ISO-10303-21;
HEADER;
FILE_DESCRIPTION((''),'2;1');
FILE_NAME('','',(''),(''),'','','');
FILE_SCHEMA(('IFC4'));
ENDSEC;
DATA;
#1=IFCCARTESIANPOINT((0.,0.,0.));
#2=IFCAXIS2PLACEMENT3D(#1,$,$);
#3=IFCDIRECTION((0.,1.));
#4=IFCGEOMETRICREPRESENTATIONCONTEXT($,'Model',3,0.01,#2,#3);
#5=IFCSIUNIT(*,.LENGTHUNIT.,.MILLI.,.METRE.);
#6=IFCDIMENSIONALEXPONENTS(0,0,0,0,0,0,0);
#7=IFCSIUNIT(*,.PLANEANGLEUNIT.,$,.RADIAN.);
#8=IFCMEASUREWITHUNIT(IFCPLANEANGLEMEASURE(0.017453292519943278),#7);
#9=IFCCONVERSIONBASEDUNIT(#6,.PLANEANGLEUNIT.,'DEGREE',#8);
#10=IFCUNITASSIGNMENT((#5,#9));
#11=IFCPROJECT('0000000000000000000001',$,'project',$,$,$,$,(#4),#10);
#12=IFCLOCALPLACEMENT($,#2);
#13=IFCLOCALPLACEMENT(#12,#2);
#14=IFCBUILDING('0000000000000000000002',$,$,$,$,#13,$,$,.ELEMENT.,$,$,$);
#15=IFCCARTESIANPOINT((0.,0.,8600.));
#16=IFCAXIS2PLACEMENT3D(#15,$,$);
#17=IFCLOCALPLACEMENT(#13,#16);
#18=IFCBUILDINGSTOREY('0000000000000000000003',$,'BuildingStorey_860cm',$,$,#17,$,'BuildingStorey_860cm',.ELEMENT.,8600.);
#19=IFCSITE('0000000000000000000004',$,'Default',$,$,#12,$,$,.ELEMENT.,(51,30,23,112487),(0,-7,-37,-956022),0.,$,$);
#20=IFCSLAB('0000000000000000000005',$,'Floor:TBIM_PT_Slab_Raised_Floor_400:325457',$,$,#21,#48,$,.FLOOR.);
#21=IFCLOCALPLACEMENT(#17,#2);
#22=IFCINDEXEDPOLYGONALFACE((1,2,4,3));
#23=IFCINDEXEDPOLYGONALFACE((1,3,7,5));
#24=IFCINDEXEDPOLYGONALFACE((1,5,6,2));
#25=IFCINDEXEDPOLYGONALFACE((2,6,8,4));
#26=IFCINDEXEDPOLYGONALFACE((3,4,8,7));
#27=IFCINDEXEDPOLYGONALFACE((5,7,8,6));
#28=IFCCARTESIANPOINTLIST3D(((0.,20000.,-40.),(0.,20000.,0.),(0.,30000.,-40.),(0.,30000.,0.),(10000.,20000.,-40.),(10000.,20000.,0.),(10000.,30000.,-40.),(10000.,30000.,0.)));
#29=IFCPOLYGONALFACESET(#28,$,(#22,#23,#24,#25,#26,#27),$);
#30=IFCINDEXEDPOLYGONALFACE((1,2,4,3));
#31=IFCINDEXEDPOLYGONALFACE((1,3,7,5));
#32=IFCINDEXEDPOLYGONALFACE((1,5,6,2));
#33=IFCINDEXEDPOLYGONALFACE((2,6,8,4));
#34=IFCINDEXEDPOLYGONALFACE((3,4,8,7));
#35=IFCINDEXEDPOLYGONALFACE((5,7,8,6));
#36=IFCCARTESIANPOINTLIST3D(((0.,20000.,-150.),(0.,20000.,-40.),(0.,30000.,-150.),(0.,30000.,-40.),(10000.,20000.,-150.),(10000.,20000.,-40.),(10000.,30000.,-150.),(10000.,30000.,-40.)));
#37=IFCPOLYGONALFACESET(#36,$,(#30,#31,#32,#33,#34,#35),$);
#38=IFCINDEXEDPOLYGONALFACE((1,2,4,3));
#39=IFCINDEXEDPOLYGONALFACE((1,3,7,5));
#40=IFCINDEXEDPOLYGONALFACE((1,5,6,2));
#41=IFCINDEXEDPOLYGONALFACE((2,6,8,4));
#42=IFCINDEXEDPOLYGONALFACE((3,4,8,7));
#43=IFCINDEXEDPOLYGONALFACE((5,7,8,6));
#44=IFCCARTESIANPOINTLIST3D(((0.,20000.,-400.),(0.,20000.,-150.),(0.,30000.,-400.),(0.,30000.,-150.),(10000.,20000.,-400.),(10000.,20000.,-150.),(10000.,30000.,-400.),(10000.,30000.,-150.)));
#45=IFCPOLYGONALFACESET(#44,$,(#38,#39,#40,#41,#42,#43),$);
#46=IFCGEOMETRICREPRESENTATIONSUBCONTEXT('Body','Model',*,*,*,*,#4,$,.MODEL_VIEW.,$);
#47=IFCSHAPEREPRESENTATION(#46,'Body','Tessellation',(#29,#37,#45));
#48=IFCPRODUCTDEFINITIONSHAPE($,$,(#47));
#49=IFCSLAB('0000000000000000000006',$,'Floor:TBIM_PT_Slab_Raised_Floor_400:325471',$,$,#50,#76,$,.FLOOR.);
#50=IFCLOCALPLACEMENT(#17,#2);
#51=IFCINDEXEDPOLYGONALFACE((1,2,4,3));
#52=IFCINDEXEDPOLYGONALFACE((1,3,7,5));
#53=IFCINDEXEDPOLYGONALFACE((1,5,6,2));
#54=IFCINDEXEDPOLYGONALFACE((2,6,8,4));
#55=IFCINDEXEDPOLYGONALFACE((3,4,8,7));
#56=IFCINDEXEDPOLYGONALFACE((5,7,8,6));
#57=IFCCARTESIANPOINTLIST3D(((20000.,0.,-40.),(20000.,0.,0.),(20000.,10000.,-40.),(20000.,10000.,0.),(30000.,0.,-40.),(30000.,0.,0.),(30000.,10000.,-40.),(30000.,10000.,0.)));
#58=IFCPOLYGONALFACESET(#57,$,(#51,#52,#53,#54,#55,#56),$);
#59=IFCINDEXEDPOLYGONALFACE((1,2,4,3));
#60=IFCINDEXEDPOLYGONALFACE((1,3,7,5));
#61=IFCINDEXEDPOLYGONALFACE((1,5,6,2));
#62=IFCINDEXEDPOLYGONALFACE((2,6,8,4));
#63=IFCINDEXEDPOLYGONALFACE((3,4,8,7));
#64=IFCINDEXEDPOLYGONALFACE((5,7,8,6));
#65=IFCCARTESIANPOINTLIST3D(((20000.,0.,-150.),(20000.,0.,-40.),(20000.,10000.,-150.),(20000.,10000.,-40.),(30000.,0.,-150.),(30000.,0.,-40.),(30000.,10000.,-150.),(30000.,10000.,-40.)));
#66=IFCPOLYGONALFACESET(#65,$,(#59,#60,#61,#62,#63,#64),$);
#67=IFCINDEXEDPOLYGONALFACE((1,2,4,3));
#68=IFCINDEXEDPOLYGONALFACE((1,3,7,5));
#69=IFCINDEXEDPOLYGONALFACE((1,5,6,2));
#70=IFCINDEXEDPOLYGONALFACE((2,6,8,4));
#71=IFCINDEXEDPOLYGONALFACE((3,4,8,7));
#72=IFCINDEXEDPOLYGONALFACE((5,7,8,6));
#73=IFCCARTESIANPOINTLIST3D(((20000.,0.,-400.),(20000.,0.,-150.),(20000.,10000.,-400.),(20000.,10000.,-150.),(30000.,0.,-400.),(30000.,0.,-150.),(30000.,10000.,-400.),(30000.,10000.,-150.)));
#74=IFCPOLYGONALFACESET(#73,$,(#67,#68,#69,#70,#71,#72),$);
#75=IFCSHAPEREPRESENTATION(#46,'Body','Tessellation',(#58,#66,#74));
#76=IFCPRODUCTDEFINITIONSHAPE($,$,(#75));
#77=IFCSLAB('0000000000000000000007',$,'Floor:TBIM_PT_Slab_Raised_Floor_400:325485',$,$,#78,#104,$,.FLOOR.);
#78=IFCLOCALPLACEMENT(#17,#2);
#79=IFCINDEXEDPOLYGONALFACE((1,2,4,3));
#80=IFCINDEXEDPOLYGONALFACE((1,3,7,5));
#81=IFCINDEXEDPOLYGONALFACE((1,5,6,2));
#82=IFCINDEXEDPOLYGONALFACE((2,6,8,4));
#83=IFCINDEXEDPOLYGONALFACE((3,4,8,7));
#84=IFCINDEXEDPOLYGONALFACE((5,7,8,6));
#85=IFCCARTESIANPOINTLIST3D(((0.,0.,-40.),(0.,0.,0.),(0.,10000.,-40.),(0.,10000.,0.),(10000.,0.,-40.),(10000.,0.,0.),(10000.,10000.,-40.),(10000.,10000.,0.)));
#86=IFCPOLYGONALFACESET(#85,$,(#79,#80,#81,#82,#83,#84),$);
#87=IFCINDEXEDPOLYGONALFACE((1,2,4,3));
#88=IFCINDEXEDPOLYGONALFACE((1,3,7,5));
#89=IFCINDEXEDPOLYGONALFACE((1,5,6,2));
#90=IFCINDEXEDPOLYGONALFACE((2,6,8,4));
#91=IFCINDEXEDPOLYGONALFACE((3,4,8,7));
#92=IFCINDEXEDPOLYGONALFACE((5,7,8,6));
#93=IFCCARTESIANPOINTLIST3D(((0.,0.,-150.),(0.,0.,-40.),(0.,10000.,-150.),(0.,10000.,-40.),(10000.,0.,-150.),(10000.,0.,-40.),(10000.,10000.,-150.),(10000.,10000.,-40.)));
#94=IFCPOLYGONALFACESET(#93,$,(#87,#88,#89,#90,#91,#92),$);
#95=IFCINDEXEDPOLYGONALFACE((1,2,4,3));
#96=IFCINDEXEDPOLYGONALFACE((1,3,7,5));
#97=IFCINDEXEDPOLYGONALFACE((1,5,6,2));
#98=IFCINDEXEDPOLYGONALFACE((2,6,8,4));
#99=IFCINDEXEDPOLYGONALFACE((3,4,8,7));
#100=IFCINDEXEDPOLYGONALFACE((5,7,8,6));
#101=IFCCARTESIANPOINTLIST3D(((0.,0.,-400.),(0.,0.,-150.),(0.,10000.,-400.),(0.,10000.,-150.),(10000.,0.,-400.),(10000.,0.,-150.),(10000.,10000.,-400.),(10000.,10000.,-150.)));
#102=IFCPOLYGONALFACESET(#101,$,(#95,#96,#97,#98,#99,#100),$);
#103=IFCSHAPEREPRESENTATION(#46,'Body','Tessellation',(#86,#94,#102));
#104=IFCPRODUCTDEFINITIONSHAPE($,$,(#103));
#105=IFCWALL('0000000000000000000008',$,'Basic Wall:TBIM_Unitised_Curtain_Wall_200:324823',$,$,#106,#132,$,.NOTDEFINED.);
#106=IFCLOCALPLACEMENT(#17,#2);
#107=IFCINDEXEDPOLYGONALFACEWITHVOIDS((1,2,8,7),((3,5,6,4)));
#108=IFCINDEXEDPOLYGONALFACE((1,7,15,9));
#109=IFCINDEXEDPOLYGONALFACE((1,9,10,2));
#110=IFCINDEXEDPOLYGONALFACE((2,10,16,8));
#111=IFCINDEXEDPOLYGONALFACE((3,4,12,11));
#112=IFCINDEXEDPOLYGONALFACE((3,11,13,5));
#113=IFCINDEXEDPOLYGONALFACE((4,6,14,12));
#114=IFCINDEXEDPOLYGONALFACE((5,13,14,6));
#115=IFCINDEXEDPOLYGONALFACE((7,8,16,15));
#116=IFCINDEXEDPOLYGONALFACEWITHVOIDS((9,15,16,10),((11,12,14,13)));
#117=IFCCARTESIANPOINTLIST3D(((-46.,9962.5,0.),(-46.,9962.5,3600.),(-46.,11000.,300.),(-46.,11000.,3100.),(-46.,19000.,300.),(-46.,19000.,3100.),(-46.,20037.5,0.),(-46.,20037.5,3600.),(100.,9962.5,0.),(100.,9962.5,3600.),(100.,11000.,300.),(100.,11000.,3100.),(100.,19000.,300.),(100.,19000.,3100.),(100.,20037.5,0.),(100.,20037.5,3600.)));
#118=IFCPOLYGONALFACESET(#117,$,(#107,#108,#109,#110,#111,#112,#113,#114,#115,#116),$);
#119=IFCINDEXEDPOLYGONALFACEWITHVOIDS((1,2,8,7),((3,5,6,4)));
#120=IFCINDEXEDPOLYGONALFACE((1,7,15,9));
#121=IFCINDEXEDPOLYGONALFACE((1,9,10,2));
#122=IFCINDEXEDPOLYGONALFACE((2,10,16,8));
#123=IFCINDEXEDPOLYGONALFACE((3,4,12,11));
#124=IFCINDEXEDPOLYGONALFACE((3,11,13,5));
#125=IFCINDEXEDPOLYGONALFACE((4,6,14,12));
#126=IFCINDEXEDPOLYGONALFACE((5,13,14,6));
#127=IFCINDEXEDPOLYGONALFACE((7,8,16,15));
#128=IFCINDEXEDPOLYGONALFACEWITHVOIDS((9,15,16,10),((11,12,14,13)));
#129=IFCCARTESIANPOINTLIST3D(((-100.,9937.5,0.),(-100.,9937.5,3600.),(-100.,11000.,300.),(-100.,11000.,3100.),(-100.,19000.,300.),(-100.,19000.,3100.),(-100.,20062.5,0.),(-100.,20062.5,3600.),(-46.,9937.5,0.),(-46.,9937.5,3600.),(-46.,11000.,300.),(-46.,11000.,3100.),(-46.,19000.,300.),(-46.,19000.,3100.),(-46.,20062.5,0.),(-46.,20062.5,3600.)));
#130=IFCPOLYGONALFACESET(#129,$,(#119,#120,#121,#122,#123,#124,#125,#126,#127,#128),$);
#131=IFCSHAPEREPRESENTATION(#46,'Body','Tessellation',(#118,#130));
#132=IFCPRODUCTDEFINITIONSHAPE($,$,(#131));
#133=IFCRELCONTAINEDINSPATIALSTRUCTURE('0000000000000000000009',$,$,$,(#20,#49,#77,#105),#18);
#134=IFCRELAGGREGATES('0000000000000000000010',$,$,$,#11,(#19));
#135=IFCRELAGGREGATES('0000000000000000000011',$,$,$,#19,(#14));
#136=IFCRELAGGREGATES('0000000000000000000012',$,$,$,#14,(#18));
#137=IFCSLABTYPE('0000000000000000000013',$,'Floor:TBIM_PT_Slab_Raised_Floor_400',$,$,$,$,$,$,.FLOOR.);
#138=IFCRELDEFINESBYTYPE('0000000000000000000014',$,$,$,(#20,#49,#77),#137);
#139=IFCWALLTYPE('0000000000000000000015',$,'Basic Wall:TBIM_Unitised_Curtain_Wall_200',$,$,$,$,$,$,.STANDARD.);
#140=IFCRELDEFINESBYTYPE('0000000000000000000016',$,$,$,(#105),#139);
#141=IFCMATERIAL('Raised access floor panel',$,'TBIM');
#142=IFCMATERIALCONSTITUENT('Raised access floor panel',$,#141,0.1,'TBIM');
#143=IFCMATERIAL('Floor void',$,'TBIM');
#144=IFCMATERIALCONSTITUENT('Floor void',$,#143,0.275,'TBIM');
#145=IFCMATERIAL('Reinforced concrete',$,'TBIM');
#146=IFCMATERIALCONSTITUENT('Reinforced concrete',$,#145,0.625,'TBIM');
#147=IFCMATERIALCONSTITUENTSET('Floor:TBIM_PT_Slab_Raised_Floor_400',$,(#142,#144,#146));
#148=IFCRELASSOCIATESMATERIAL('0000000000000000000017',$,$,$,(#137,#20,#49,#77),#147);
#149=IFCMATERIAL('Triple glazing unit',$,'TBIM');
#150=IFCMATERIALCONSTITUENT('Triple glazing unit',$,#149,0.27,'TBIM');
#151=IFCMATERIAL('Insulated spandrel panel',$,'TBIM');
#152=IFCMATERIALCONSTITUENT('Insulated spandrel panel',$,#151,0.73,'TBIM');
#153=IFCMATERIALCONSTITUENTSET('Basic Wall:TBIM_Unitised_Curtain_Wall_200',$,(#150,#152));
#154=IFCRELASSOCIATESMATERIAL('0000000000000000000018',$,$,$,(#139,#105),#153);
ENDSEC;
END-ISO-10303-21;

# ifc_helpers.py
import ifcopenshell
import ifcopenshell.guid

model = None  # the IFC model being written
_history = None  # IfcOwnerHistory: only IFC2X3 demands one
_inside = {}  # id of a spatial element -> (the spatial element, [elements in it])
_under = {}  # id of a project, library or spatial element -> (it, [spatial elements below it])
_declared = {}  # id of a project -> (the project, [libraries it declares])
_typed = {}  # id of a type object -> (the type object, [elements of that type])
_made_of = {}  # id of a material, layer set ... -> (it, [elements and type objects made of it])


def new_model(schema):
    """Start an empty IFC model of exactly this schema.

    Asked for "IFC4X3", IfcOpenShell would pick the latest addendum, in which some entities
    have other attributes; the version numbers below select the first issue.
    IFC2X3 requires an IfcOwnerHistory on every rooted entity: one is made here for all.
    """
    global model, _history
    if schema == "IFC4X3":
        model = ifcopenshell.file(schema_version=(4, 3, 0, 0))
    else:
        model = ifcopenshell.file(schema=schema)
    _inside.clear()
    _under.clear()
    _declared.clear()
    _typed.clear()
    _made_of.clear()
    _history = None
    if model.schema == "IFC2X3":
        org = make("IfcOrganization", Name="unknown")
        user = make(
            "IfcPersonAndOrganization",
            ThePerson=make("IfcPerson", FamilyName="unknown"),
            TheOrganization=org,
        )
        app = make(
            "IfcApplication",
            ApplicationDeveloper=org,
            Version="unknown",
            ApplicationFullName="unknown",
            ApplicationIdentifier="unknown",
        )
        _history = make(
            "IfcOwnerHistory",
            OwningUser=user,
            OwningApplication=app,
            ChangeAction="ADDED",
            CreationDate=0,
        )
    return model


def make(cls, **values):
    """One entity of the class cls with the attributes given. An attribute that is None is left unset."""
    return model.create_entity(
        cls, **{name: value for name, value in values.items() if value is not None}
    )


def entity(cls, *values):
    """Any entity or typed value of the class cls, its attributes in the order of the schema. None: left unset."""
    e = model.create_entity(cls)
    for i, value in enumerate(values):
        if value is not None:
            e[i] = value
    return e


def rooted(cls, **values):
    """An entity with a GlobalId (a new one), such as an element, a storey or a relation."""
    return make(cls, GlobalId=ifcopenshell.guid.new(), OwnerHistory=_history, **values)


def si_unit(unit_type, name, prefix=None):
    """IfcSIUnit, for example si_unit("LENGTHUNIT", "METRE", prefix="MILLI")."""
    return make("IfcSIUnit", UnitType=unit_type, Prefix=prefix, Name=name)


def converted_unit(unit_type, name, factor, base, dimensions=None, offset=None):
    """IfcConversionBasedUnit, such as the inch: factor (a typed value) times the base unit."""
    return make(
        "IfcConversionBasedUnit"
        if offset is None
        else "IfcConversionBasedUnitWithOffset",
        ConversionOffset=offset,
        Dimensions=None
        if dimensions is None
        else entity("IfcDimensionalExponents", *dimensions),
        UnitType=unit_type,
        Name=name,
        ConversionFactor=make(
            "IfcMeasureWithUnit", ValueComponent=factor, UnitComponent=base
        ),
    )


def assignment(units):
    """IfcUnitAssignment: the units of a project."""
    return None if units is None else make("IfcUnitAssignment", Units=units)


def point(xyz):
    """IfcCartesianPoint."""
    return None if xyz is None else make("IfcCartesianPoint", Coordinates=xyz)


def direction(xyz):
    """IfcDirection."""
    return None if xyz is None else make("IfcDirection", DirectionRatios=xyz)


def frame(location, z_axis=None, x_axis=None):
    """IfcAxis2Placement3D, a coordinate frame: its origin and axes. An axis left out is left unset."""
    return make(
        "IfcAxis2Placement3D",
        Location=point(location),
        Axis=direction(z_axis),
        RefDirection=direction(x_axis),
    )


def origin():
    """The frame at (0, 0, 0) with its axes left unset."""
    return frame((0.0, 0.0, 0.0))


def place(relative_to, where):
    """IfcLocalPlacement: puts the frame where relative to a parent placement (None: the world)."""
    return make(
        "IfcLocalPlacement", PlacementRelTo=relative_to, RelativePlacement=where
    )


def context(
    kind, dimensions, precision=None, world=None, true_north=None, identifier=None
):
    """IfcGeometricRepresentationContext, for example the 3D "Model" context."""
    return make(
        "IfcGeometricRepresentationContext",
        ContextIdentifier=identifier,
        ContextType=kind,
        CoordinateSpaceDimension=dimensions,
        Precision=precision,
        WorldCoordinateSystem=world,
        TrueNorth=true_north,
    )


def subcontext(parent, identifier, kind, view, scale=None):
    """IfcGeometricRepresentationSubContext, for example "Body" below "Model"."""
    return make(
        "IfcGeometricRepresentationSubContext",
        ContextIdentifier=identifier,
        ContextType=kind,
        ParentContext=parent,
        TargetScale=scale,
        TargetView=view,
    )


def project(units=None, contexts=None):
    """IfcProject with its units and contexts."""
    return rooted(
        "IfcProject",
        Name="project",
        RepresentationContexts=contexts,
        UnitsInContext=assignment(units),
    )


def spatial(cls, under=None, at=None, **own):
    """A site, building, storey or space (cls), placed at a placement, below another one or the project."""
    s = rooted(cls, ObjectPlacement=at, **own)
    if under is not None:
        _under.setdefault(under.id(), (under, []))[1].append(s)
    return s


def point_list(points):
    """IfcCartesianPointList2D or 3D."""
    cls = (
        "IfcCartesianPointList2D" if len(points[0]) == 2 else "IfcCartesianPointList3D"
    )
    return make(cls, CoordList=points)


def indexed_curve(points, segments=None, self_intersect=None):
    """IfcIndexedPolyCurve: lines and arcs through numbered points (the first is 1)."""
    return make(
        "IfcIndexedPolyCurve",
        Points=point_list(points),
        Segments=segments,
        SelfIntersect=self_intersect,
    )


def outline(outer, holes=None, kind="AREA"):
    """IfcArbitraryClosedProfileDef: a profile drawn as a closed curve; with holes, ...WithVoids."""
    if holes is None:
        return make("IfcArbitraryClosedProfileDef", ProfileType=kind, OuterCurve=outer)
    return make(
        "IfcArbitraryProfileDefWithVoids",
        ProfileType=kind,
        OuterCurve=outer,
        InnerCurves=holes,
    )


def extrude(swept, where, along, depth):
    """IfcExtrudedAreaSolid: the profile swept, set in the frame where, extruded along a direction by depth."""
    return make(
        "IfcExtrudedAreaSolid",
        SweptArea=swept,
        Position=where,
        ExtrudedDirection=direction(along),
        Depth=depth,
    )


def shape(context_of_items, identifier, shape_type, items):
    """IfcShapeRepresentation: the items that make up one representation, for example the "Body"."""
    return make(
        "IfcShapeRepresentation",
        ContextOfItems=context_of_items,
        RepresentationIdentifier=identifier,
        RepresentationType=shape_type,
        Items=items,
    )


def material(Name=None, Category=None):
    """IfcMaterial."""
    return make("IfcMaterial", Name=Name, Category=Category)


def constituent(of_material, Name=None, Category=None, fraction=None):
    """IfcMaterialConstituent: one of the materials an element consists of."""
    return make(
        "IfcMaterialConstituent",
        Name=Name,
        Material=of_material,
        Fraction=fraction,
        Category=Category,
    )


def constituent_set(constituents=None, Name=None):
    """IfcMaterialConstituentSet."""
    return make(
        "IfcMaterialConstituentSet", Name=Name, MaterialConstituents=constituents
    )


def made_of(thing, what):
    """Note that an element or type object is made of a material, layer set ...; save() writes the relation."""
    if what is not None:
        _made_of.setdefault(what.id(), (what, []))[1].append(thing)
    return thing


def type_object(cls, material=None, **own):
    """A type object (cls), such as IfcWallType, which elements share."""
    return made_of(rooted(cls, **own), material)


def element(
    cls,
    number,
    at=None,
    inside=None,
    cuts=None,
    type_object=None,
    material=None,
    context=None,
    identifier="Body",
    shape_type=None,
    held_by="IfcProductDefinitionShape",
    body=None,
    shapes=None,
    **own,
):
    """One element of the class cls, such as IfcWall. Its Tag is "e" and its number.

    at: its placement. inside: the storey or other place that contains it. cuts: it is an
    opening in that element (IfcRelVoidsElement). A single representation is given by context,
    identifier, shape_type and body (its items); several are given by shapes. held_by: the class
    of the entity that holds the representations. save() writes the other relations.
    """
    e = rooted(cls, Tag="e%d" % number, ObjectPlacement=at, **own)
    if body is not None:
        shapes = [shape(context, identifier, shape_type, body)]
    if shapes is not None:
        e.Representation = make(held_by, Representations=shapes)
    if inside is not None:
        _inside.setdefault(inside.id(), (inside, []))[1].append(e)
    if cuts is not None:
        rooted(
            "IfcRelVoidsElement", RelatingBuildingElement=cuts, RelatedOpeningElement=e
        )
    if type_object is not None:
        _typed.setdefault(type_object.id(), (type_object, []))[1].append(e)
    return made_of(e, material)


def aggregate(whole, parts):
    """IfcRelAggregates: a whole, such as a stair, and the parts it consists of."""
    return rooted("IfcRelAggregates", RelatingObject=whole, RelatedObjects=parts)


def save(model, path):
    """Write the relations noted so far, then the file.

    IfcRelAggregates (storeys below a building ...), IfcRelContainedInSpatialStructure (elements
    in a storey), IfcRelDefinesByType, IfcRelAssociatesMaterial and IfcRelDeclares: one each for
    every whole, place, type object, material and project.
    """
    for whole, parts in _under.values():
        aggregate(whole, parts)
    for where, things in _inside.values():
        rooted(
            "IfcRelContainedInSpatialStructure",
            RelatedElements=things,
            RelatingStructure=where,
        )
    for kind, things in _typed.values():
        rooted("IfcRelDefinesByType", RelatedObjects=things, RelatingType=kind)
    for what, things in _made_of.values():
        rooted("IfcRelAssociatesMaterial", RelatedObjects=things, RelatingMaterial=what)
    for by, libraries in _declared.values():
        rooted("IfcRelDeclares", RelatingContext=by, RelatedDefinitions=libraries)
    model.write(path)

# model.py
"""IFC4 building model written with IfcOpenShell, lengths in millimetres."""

from ifc_helpers import new_model, entity, si_unit, converted_unit, direction, frame, origin, place, context, subcontext, project, spatial, indexed_curve, outline, extrude, material, constituent, constituent_set, type_object, element, save


model = new_model("IFC4")

# Units and contexts
model_context = context("Model", 3, precision=0.01, world=origin(), true_north=direction((0.0, 1.0)))
body_context = subcontext(model_context, "Body", "Model", "MODEL_VIEW")
ifc_project = project(units=[si_unit("LENGTHUNIT", "METRE", prefix="MILLI"), converted_unit("PLANEANGLEUNIT", "DEGREE", entity("IfcPlaneAngleMeasure", 0.017453292519943278), si_unit("PLANEANGLEUNIT", "RADIAN"), dimensions=[0, 0, 0, 0, 0, 0, 0])], contexts=[model_context])

# Site, building, storey
site_placement = place(None, origin())
site = spatial("IfcSite", under=ifc_project, at=site_placement, Name="Default", CompositionType="ELEMENT", RefLatitude=(51, 30, 23, 112487), RefLongitude=(0, -7, -37, -956022), RefElevation=0.0)
building_placement = place(site_placement, origin())
building = spatial("IfcBuilding", under=site, at=building_placement, CompositionType="ELEMENT")
storey_placement = place(building_placement, frame((0.0, 0.0, 8600.0)))
storey = spatial("IfcBuildingStorey", under=building, at=storey_placement, Name="BuildingStorey_860cm", LongName="BuildingStorey_860cm", CompositionType="ELEMENT", Elevation=8600.0)

# Slabs
ifc_material_1 = material(Name="Raised access floor panel", Category="TBIM")
ifc_constituent_1 = constituent(ifc_material_1, Name="Raised access floor panel", Category="TBIM", fraction=0.1)
ifc_material_2 = material(Name="Floor void", Category="TBIM")
ifc_constituent_2 = constituent(ifc_material_2, Name="Floor void", Category="TBIM", fraction=0.275)
ifc_material_3 = material(Name="Reinforced concrete", Category="TBIM")
ifc_constituent_3 = constituent(ifc_material_3, Name="Reinforced concrete", Category="TBIM", fraction=0.625)
ifc_constituent_set_1 = constituent_set(constituents=[ifc_constituent_1, ifc_constituent_2, ifc_constituent_3], Name="Floor:TBIM_PT_Slab_Raised_Floor_400")
slab_type = type_object("IfcSlabType", Name="Floor:TBIM_PT_Slab_Raised_Floor_400", PredefinedType="FLOOR", material=ifc_constituent_set_1)
slab_1_placement = place(storey_placement, origin())
element("IfcSlab", 1, at=slab_1_placement, inside=storey, type_object=slab_type, material=ifc_constituent_set_1, Name="Floor:TBIM_PT_Slab_Raised_Floor_400:325457", PredefinedType="FLOOR", context=body_context, shape_type="SweptSolid", body=[
    extrude(outline(indexed_curve([(-5000.0, -5000.0), (5000.0, -5000.0), (5000.0, 5000.0), (-5000.0, 5000.0), (-5000.0, -5000.0)], self_intersect=False)), frame((5000.0, 25000.0, -40.0), z_axis=(0.0, 0.0, 1.0), x_axis=(-1.0, 0.0, 0.0)), (0.0, 0.0, 1.0), 40.0),
    extrude(outline(indexed_curve([(-5000.0, -5000.0), (5000.0, -5000.0), (5000.0, 5000.0), (-5000.0, 5000.0), (-5000.0, -5000.0)], self_intersect=False)), frame((5000.0, 25000.0, -150.0), z_axis=(0.0, 0.0, 1.0), x_axis=(-1.0, 0.0, 0.0)), (0.0, 0.0, 1.0), 110.0),
    extrude(outline(indexed_curve([(-5000.0, -5000.0), (5000.0, -5000.0), (5000.0, 5000.0), (-5000.0, 5000.0), (-5000.0, -5000.0)], self_intersect=False)), frame((5000.0, 25000.0, -400.0), z_axis=(0.0, 0.0, 1.0), x_axis=(-1.0, 0.0, 0.0)), (0.0, 0.0, 1.0), 250.0),
])
slab_2_placement = place(storey_placement, origin())
element("IfcSlab", 2, at=slab_2_placement, inside=storey, type_object=slab_type, material=ifc_constituent_set_1, Name="Floor:TBIM_PT_Slab_Raised_Floor_400:325471", PredefinedType="FLOOR", context=body_context, shape_type="SweptSolid", body=[
    extrude(outline(indexed_curve([(-5000.0, -5000.0), (5000.0, -5000.0), (5000.0, 5000.0), (-5000.0, 5000.0), (-5000.0, -5000.0)], self_intersect=False)), frame((25000.0, 5000.0, -40.0), z_axis=(0.0, 0.0, 1.0), x_axis=(-1.0, 0.0, 0.0)), (0.0, 0.0, 1.0), 40.0),
    extrude(outline(indexed_curve([(-5000.0, -5000.0), (5000.0, -5000.0), (5000.0, 5000.0), (-5000.0, 5000.0), (-5000.0, -5000.0)], self_intersect=False)), frame((25000.0, 5000.0, -150.0), z_axis=(0.0, 0.0, 1.0), x_axis=(-1.0, 0.0, 0.0)), (0.0, 0.0, 1.0), 110.0),
    extrude(outline(indexed_curve([(-5000.0, -5000.0), (5000.0, -5000.0), (5000.0, 5000.0), (-5000.0, 5000.0), (-5000.0, -5000.0)], self_intersect=False)), frame((25000.0, 5000.0, -400.0), z_axis=(0.0, 0.0, 1.0), x_axis=(-1.0, 0.0, 0.0)), (0.0, 0.0, 1.0), 250.0),
])
slab_3_placement = place(storey_placement, origin())
element("IfcSlab", 3, at=slab_3_placement, inside=storey, type_object=slab_type, material=ifc_constituent_set_1, Name="Floor:TBIM_PT_Slab_Raised_Floor_400:325485", PredefinedType="FLOOR", context=body_context, shape_type="SweptSolid", body=[
    extrude(outline(indexed_curve([(-5000.0, -5000.0), (5000.0, -5000.0), (5000.0, 5000.0), (-5000.0, 5000.0), (-5000.0, -5000.0)], self_intersect=False)), frame((5000.0, 5000.0, -40.0), z_axis=(0.0, 0.0, 1.0), x_axis=(-1.0, 0.0, 0.0)), (0.0, 0.0, 1.0), 40.0),
    extrude(outline(indexed_curve([(-5000.0, -5000.0), (5000.0, -5000.0), (5000.0, 5000.0), (-5000.0, 5000.0), (-5000.0, -5000.0)], self_intersect=False)), frame((5000.0, 5000.0, -150.0), z_axis=(0.0, 0.0, 1.0), x_axis=(-1.0, 0.0, 0.0)), (0.0, 0.0, 1.0), 110.0),
    extrude(outline(indexed_curve([(-5000.0, -5000.0), (5000.0, -5000.0), (5000.0, 5000.0), (-5000.0, 5000.0), (-5000.0, -5000.0)], self_intersect=False)), frame((5000.0, 5000.0, -400.0), z_axis=(0.0, 0.0, 1.0), x_axis=(-1.0, 0.0, 0.0)), (0.0, 0.0, 1.0), 250.0),
])

# Wall, opening
ifc_material_4 = material(Name="Triple glazing unit", Category="TBIM")
ifc_constituent_4 = constituent(ifc_material_4, Name="Triple glazing unit", Category="TBIM", fraction=0.27)
ifc_material_5 = material(Name="Insulated spandrel panel", Category="TBIM")
ifc_constituent_5 = constituent(ifc_material_5, Name="Insulated spandrel panel", Category="TBIM", fraction=0.73)
ifc_constituent_set_2 = constituent_set(constituents=[ifc_constituent_4, ifc_constituent_5], Name="Basic Wall:TBIM_Unitised_Curtain_Wall_200")
wall_type = type_object("IfcWallType", Name="Basic Wall:TBIM_Unitised_Curtain_Wall_200", PredefinedType="STANDARD", material=ifc_constituent_set_2)
wall_1_placement = place(storey_placement, frame((0.0, 9937.5, 0.0), z_axis=(0.0, 0.0, 1.0), x_axis=(0.0, 1.0, 0.0)))
wall_1 = element("IfcWall", 4, at=wall_1_placement, inside=storey, type_object=wall_type, material=ifc_constituent_set_2, Name="Basic Wall:TBIM_Unitised_Curtain_Wall_200:324823", PredefinedType="NOTDEFINED", context=body_context, shape_type="SweptSolid", body=[
    extrude(outline(indexed_curve([(-1800.0, -5037.5), (1800.0, -5037.5), (1800.0, 5037.5), (-1800.0, 5037.5), (-1800.0, -5037.5)], self_intersect=False), holes=[indexed_curve([(1300.0, 4000.0), (1300.0, -4000.0), (-1500.0, -4000.0), (-1500.0, 4000.0), (1300.0, 4000.0)], self_intersect=False)]), frame((5062.5, 46.0, 1800.0), z_axis=(0.0, -1.0, 0.0), x_axis=(0.0, 0.0, 1.0)), (0.0, 0.0, 1.0), 146.0),
    extrude(outline(indexed_curve([(-5062.5, -1800.0), (5062.5, -1800.0), (5062.5, 1800.0), (-5062.5, 1800.0), (-5062.5, -1800.0)], self_intersect=False), holes=[indexed_curve([(-4000.0, 1300.0), (4000.0, 1300.0), (4000.0, -1500.0), (-4000.0, -1500.0), (-4000.0, 1300.0)], self_intersect=False)]), frame((5062.5, 100.0, 1800.0), z_axis=(0.0, -1.0, 0.0), x_axis=(1.0, 0.0, 0.0)), (0.0, 0.0, 1.0), 54.0),
])
opening_1_placement = place(wall_1_placement, frame((1062.5, -100.0, 300.0)))
element("IfcOpeningElement", 5, at=opening_1_placement, cuts=wall_1, PredefinedType="OPENING", context=body_context, shape_type="SweptSolid", body=[
    extrude(outline(indexed_curve([(2800.0, 0.0), (2800.0, 8000.0), (0.0, 8000.0), (0.0, 0.0), (2800.0, 0.0)], self_intersect=False)), frame((0.0, 0.0, 0.0), z_axis=(0.0, 1.0, 0.0), x_axis=(0.0, 0.0, 1.0)), (0.0, 0.0, 1.0), 200.0),
])

save(model, "model.ifc")
